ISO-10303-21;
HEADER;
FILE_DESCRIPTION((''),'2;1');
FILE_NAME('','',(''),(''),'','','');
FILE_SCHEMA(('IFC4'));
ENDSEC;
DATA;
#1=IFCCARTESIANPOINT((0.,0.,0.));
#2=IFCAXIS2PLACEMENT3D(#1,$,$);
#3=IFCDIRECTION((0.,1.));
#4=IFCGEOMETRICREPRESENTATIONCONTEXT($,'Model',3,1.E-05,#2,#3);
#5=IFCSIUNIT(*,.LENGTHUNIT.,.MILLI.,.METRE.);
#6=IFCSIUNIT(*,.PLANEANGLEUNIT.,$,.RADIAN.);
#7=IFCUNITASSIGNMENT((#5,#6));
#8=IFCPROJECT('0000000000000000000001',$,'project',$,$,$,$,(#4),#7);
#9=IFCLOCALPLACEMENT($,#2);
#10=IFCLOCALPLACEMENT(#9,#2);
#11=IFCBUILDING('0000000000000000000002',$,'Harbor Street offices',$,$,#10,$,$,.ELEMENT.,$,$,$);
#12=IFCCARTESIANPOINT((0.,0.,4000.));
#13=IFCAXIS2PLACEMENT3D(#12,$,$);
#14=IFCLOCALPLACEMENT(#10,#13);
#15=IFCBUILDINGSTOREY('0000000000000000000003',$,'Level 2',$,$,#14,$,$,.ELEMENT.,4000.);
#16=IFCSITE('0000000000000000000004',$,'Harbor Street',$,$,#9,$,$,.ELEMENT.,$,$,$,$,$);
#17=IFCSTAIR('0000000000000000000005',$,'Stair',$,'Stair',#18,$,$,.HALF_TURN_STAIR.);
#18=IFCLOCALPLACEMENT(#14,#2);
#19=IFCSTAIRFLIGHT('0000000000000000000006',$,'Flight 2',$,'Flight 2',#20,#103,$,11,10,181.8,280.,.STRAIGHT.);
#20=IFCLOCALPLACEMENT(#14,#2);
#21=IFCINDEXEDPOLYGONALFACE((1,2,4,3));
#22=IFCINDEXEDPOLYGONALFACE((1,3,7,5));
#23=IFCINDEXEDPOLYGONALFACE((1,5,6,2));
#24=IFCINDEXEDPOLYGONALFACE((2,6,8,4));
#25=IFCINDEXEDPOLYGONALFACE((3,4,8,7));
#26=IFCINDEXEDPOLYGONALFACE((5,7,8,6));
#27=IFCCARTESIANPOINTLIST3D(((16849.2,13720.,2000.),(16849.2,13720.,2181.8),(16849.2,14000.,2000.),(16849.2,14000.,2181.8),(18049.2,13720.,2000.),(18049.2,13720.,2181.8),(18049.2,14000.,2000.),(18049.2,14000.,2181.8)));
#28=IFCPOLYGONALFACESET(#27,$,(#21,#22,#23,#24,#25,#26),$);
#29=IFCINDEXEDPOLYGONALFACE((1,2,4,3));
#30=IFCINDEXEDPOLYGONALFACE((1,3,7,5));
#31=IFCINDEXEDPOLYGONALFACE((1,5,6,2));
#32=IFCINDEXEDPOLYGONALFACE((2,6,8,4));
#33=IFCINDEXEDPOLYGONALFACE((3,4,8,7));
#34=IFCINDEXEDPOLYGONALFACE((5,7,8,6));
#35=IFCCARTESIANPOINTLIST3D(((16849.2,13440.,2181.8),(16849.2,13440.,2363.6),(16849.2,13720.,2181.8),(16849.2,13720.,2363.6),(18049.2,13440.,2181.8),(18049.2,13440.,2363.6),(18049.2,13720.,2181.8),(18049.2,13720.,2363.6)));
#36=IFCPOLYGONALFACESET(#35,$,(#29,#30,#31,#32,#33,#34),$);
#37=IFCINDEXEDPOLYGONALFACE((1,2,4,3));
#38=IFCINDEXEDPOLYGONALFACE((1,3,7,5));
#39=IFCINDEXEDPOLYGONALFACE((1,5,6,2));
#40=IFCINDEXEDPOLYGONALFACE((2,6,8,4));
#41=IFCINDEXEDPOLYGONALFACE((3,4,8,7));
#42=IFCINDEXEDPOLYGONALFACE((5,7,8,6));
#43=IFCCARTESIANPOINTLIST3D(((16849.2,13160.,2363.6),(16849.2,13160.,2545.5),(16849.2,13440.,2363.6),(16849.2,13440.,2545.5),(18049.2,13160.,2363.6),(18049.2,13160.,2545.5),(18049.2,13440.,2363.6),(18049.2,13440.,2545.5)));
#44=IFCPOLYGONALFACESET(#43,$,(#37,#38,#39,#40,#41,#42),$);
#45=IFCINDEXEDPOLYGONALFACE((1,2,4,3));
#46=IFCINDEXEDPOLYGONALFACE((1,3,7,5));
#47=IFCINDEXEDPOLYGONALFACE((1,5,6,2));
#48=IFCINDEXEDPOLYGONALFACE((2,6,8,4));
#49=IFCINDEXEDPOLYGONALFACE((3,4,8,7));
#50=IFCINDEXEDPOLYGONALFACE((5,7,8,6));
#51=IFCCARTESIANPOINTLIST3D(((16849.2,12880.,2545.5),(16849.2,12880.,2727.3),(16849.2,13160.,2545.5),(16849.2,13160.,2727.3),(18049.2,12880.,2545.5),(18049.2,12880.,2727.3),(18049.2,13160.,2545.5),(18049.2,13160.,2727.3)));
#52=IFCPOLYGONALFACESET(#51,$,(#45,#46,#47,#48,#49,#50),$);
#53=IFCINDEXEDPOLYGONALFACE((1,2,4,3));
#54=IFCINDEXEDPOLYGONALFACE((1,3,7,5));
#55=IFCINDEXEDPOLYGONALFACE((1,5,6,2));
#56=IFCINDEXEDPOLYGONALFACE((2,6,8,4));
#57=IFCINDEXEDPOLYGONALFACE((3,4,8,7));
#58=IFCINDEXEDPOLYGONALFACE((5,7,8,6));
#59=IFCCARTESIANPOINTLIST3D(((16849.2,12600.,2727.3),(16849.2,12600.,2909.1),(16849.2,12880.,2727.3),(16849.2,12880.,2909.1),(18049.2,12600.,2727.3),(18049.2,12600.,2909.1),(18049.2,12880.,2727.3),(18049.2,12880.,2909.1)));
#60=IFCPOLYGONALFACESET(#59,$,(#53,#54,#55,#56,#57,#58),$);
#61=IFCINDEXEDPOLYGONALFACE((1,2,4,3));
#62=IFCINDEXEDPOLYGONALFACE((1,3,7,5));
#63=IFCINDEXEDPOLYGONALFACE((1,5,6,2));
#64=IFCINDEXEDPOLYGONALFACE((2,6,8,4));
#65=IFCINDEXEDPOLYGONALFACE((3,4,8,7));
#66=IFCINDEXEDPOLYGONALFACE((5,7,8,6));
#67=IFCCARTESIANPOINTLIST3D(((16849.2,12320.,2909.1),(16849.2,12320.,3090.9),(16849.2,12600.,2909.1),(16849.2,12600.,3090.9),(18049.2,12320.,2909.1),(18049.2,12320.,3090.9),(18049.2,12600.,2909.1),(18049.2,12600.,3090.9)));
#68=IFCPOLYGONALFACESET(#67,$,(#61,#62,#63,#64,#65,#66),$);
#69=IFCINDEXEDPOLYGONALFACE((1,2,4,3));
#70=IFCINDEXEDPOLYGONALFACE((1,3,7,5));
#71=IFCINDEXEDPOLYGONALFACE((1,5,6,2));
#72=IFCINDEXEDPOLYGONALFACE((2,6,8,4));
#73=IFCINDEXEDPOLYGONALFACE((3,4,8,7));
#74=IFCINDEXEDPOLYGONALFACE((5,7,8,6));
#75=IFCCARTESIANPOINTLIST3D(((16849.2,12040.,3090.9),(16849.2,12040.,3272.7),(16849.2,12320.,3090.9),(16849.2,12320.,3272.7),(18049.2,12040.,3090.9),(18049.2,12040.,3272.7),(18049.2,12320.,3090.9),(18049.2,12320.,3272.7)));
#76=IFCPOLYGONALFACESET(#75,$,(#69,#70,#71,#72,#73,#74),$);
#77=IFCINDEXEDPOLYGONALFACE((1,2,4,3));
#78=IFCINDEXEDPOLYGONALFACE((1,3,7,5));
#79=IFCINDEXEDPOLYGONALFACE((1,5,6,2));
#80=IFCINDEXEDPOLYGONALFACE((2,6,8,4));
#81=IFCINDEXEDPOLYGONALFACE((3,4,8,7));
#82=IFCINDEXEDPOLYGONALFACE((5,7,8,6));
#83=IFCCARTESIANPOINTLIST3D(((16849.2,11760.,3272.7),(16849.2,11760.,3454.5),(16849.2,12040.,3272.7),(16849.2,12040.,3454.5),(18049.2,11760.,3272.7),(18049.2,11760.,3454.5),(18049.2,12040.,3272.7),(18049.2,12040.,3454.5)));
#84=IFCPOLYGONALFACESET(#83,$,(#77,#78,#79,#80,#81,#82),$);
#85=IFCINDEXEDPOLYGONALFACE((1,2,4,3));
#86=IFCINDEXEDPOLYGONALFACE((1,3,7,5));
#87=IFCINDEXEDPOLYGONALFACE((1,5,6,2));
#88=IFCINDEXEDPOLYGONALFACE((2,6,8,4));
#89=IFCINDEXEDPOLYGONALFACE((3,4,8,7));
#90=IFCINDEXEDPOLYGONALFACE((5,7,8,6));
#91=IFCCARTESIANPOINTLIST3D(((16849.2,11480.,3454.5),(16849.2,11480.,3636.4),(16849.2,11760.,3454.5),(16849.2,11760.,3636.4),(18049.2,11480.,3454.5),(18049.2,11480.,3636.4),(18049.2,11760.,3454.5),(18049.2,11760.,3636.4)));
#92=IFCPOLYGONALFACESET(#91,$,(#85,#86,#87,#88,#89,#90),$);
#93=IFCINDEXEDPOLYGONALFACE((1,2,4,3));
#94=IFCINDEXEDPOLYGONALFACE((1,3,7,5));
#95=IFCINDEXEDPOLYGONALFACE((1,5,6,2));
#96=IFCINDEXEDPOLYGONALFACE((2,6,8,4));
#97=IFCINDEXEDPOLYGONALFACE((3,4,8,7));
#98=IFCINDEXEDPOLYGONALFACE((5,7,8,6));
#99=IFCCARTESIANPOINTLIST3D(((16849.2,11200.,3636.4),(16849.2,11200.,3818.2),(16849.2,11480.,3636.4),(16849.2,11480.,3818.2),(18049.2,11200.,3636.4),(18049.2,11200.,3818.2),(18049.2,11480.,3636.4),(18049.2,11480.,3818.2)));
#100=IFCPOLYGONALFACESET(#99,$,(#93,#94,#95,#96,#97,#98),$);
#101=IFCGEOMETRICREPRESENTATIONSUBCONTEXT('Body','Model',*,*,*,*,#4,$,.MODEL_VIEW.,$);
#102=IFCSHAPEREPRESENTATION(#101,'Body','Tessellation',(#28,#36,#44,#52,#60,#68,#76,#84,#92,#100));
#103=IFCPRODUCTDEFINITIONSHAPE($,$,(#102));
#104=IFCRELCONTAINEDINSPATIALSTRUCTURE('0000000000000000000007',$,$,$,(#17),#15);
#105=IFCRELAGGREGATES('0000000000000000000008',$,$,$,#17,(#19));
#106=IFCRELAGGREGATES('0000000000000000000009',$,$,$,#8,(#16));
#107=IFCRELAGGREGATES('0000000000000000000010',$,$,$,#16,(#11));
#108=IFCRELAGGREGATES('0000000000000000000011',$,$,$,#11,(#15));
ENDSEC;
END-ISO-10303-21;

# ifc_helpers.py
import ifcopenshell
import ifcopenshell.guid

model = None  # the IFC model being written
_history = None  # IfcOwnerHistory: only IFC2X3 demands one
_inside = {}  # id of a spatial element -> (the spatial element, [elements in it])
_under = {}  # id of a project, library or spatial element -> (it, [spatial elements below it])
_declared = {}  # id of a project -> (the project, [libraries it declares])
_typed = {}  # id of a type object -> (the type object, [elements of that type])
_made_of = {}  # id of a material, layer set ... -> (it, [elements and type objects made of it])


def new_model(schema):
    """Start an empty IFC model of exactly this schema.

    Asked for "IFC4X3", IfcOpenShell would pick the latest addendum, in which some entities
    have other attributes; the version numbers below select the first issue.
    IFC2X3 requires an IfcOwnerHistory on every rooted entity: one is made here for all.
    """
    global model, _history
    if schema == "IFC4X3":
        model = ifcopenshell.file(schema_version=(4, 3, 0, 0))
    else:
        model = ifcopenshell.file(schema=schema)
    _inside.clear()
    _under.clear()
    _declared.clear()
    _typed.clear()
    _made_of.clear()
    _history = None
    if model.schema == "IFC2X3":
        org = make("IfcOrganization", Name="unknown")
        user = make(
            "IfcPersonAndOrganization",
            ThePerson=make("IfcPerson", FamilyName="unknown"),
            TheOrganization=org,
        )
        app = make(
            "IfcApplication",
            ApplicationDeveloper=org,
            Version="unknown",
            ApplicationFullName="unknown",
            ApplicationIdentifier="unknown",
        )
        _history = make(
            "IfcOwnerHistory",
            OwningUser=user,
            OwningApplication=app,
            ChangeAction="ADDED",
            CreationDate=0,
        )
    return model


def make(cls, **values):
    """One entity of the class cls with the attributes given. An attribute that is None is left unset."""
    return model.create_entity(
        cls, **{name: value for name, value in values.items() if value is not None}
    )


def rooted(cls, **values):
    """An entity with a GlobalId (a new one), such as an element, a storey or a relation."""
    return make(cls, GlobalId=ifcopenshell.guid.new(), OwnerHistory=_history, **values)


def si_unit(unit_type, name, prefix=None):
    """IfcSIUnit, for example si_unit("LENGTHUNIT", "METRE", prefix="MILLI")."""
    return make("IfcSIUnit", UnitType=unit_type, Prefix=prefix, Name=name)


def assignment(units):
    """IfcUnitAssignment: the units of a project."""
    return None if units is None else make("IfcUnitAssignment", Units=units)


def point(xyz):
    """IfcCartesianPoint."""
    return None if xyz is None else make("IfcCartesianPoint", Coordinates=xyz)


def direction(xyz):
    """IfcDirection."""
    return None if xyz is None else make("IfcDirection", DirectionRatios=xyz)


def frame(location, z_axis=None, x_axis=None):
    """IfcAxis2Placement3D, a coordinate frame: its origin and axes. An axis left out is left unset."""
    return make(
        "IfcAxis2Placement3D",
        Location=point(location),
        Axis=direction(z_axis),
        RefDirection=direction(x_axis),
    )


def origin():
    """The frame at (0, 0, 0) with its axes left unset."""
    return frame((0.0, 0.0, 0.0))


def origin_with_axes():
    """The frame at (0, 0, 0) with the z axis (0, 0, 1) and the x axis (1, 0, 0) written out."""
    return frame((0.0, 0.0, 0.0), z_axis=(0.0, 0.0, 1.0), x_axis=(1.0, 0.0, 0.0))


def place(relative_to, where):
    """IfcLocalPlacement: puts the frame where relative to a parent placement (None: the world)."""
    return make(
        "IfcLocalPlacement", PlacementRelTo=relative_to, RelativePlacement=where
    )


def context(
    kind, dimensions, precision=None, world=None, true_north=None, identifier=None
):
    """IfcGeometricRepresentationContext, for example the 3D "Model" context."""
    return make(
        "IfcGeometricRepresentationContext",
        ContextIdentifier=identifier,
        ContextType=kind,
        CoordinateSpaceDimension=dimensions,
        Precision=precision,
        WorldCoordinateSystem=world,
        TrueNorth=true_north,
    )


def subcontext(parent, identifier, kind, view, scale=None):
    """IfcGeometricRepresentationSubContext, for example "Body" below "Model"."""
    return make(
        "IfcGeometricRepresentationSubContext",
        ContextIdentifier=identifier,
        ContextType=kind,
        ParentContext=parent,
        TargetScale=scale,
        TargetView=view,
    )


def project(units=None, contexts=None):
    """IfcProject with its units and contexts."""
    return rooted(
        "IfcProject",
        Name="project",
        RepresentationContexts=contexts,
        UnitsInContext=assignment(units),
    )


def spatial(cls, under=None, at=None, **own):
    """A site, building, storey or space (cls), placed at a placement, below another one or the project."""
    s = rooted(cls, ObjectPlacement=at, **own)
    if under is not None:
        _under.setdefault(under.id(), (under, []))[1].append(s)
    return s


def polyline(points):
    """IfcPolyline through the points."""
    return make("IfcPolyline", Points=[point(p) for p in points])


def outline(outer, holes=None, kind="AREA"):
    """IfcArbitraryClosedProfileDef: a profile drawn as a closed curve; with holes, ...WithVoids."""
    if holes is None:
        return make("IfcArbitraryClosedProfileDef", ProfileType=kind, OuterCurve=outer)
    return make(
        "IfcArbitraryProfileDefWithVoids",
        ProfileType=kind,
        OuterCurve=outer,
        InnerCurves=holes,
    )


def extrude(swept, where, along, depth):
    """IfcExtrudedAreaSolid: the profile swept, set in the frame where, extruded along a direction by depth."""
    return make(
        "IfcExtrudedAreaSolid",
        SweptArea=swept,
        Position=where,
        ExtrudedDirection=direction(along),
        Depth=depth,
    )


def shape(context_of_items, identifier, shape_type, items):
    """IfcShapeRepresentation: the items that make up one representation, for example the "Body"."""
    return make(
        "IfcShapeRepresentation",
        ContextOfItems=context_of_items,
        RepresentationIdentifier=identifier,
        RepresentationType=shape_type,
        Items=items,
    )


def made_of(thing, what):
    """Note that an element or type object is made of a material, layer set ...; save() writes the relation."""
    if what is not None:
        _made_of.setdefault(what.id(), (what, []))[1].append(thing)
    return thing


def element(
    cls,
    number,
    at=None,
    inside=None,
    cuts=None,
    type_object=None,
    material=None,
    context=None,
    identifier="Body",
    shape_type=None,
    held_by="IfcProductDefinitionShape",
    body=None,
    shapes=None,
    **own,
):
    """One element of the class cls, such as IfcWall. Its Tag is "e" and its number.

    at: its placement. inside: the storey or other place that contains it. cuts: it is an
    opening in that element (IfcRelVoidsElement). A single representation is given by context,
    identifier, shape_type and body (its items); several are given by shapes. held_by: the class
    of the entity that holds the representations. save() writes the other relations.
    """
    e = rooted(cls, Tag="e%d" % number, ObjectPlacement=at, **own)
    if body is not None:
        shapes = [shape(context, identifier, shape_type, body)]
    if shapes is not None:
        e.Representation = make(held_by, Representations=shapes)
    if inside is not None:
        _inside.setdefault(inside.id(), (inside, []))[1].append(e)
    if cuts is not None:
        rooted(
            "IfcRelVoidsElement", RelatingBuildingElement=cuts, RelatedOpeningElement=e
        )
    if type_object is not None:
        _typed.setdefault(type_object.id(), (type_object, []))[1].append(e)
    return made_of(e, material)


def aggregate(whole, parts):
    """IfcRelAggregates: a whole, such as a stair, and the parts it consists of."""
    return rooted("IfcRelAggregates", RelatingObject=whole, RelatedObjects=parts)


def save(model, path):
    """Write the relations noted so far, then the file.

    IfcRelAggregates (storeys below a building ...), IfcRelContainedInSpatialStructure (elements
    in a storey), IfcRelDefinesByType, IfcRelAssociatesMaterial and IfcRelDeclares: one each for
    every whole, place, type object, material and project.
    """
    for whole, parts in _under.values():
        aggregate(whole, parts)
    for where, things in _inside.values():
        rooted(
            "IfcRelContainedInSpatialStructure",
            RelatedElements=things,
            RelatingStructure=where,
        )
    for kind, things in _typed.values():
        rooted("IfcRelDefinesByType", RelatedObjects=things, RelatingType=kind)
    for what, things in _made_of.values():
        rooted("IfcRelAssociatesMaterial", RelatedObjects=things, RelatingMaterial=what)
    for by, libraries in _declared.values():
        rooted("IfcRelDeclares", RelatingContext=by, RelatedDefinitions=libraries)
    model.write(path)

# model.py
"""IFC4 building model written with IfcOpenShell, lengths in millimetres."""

from ifc_helpers import new_model, si_unit, direction, frame, origin, origin_with_axes, place, context, subcontext, project, spatial, polyline, outline, extrude, element, aggregate, save


model = new_model("IFC4")

# Units and contexts
model_context = context("Model", 3, precision=1e-05, world=origin(), true_north=direction((0.0, 1.0)))
body_context = subcontext(model_context, "Body", "Model", "MODEL_VIEW")
ifc_project = project(units=[si_unit("LENGTHUNIT", "METRE", prefix="MILLI"), si_unit("PLANEANGLEUNIT", "RADIAN")], contexts=[model_context])

# Site, building, storey
site_placement = place(None, origin())
site = spatial("IfcSite", under=ifc_project, at=site_placement, Name="Harbor Street", CompositionType="ELEMENT")
building_placement = place(site_placement, origin())
building = spatial("IfcBuilding", under=site, at=building_placement, Name="Harbor Street offices", CompositionType="ELEMENT")
storey_placement = place(building_placement, frame((0.0, 0.0, 4000.0)))
storey = spatial("IfcBuildingStorey", under=building, at=storey_placement, Name="Level 2", CompositionType="ELEMENT", Elevation=4000.0)

# Stair
stair_placement = place(storey_placement, origin_with_axes())
stair = element("IfcStair", 1, at=stair_placement, inside=storey, Name="Stair", ObjectType="Stair", PredefinedType="HALF_TURN_STAIR")

# Stair flight
stair_flight_1_placement = place(storey_placement, origin_with_axes())
stair_flight_1 = element("IfcStairFlight", 2, at=stair_flight_1_placement, Name="Flight 2", ObjectType="Flight 2", NumberOfRisers=11, NumberOfTreads=10, PredefinedType="STRAIGHT", RiserHeight=181.8, TreadLength=280.0, context=body_context, shape_type="SweptSolid", body=[
    extrude(outline(polyline([(18049.2, 13720.0), (18049.2, 14000.0), (16849.2, 14000.0), (16849.2, 13720.0), (18049.2, 13720.0)])), frame((0.0, 0.0, 2000.0)), (0.0, 0.0, 1.0), 181.8),
    extrude(outline(polyline([(18049.2, 13440.0), (18049.2, 13720.0), (16849.2, 13720.0), (16849.2, 13440.0), (18049.2, 13440.0)])), frame((0.0, 0.0, 2181.8)), (0.0, 0.0, 1.0), 181.8),
    extrude(outline(polyline([(18049.2, 13160.0), (18049.2, 13440.0), (16849.2, 13440.0), (16849.2, 13160.0), (18049.2, 13160.0)])), frame((0.0, 0.0, 2363.6)), (0.0, 0.0, 1.0), 181.8),
    extrude(outline(polyline([(18049.2, 12880.0), (18049.2, 13160.0), (16849.2, 13160.0), (16849.2, 12880.0), (18049.2, 12880.0)])), frame((0.0, 0.0, 2545.5)), (0.0, 0.0, 1.0), 181.8),
    extrude(outline(polyline([(18049.2, 12600.0), (18049.2, 12880.0), (16849.2, 12880.0), (16849.2, 12600.0), (18049.2, 12600.0)])), frame((0.0, 0.0, 2727.3)), (0.0, 0.0, 1.0), 181.8),
    extrude(outline(polyline([(18049.2, 12320.0), (18049.2, 12600.0), (16849.2, 12600.0), (16849.2, 12320.0), (18049.2, 12320.0)])), frame((0.0, 0.0, 2909.1)), (0.0, 0.0, 1.0), 181.8),
    extrude(outline(polyline([(18049.2, 12040.0), (18049.2, 12320.0), (16849.2, 12320.0), (16849.2, 12040.0), (18049.2, 12040.0)])), frame((0.0, 0.0, 3090.9)), (0.0, 0.0, 1.0), 181.8),
    extrude(outline(polyline([(18049.2, 11760.0), (18049.2, 12040.0), (16849.2, 12040.0), (16849.2, 11760.0), (18049.2, 11760.0)])), frame((0.0, 0.0, 3272.7)), (0.0, 0.0, 1.0), 181.8),
    extrude(outline(polyline([(18049.2, 11480.0), (18049.2, 11760.0), (16849.2, 11760.0), (16849.2, 11480.0), (18049.2, 11480.0)])), frame((0.0, 0.0, 3454.5)), (0.0, 0.0, 1.0), 181.8),
    extrude(outline(polyline([(18049.2, 11200.0), (18049.2, 11480.0), (16849.2, 11480.0), (16849.2, 11200.0), (18049.2, 11200.0)])), frame((0.0, 0.0, 3636.4)), (0.0, 0.0, 1.0), 181.8),
])

aggregate(stair, [stair_flight_1])

save(model, "model.ifc")
